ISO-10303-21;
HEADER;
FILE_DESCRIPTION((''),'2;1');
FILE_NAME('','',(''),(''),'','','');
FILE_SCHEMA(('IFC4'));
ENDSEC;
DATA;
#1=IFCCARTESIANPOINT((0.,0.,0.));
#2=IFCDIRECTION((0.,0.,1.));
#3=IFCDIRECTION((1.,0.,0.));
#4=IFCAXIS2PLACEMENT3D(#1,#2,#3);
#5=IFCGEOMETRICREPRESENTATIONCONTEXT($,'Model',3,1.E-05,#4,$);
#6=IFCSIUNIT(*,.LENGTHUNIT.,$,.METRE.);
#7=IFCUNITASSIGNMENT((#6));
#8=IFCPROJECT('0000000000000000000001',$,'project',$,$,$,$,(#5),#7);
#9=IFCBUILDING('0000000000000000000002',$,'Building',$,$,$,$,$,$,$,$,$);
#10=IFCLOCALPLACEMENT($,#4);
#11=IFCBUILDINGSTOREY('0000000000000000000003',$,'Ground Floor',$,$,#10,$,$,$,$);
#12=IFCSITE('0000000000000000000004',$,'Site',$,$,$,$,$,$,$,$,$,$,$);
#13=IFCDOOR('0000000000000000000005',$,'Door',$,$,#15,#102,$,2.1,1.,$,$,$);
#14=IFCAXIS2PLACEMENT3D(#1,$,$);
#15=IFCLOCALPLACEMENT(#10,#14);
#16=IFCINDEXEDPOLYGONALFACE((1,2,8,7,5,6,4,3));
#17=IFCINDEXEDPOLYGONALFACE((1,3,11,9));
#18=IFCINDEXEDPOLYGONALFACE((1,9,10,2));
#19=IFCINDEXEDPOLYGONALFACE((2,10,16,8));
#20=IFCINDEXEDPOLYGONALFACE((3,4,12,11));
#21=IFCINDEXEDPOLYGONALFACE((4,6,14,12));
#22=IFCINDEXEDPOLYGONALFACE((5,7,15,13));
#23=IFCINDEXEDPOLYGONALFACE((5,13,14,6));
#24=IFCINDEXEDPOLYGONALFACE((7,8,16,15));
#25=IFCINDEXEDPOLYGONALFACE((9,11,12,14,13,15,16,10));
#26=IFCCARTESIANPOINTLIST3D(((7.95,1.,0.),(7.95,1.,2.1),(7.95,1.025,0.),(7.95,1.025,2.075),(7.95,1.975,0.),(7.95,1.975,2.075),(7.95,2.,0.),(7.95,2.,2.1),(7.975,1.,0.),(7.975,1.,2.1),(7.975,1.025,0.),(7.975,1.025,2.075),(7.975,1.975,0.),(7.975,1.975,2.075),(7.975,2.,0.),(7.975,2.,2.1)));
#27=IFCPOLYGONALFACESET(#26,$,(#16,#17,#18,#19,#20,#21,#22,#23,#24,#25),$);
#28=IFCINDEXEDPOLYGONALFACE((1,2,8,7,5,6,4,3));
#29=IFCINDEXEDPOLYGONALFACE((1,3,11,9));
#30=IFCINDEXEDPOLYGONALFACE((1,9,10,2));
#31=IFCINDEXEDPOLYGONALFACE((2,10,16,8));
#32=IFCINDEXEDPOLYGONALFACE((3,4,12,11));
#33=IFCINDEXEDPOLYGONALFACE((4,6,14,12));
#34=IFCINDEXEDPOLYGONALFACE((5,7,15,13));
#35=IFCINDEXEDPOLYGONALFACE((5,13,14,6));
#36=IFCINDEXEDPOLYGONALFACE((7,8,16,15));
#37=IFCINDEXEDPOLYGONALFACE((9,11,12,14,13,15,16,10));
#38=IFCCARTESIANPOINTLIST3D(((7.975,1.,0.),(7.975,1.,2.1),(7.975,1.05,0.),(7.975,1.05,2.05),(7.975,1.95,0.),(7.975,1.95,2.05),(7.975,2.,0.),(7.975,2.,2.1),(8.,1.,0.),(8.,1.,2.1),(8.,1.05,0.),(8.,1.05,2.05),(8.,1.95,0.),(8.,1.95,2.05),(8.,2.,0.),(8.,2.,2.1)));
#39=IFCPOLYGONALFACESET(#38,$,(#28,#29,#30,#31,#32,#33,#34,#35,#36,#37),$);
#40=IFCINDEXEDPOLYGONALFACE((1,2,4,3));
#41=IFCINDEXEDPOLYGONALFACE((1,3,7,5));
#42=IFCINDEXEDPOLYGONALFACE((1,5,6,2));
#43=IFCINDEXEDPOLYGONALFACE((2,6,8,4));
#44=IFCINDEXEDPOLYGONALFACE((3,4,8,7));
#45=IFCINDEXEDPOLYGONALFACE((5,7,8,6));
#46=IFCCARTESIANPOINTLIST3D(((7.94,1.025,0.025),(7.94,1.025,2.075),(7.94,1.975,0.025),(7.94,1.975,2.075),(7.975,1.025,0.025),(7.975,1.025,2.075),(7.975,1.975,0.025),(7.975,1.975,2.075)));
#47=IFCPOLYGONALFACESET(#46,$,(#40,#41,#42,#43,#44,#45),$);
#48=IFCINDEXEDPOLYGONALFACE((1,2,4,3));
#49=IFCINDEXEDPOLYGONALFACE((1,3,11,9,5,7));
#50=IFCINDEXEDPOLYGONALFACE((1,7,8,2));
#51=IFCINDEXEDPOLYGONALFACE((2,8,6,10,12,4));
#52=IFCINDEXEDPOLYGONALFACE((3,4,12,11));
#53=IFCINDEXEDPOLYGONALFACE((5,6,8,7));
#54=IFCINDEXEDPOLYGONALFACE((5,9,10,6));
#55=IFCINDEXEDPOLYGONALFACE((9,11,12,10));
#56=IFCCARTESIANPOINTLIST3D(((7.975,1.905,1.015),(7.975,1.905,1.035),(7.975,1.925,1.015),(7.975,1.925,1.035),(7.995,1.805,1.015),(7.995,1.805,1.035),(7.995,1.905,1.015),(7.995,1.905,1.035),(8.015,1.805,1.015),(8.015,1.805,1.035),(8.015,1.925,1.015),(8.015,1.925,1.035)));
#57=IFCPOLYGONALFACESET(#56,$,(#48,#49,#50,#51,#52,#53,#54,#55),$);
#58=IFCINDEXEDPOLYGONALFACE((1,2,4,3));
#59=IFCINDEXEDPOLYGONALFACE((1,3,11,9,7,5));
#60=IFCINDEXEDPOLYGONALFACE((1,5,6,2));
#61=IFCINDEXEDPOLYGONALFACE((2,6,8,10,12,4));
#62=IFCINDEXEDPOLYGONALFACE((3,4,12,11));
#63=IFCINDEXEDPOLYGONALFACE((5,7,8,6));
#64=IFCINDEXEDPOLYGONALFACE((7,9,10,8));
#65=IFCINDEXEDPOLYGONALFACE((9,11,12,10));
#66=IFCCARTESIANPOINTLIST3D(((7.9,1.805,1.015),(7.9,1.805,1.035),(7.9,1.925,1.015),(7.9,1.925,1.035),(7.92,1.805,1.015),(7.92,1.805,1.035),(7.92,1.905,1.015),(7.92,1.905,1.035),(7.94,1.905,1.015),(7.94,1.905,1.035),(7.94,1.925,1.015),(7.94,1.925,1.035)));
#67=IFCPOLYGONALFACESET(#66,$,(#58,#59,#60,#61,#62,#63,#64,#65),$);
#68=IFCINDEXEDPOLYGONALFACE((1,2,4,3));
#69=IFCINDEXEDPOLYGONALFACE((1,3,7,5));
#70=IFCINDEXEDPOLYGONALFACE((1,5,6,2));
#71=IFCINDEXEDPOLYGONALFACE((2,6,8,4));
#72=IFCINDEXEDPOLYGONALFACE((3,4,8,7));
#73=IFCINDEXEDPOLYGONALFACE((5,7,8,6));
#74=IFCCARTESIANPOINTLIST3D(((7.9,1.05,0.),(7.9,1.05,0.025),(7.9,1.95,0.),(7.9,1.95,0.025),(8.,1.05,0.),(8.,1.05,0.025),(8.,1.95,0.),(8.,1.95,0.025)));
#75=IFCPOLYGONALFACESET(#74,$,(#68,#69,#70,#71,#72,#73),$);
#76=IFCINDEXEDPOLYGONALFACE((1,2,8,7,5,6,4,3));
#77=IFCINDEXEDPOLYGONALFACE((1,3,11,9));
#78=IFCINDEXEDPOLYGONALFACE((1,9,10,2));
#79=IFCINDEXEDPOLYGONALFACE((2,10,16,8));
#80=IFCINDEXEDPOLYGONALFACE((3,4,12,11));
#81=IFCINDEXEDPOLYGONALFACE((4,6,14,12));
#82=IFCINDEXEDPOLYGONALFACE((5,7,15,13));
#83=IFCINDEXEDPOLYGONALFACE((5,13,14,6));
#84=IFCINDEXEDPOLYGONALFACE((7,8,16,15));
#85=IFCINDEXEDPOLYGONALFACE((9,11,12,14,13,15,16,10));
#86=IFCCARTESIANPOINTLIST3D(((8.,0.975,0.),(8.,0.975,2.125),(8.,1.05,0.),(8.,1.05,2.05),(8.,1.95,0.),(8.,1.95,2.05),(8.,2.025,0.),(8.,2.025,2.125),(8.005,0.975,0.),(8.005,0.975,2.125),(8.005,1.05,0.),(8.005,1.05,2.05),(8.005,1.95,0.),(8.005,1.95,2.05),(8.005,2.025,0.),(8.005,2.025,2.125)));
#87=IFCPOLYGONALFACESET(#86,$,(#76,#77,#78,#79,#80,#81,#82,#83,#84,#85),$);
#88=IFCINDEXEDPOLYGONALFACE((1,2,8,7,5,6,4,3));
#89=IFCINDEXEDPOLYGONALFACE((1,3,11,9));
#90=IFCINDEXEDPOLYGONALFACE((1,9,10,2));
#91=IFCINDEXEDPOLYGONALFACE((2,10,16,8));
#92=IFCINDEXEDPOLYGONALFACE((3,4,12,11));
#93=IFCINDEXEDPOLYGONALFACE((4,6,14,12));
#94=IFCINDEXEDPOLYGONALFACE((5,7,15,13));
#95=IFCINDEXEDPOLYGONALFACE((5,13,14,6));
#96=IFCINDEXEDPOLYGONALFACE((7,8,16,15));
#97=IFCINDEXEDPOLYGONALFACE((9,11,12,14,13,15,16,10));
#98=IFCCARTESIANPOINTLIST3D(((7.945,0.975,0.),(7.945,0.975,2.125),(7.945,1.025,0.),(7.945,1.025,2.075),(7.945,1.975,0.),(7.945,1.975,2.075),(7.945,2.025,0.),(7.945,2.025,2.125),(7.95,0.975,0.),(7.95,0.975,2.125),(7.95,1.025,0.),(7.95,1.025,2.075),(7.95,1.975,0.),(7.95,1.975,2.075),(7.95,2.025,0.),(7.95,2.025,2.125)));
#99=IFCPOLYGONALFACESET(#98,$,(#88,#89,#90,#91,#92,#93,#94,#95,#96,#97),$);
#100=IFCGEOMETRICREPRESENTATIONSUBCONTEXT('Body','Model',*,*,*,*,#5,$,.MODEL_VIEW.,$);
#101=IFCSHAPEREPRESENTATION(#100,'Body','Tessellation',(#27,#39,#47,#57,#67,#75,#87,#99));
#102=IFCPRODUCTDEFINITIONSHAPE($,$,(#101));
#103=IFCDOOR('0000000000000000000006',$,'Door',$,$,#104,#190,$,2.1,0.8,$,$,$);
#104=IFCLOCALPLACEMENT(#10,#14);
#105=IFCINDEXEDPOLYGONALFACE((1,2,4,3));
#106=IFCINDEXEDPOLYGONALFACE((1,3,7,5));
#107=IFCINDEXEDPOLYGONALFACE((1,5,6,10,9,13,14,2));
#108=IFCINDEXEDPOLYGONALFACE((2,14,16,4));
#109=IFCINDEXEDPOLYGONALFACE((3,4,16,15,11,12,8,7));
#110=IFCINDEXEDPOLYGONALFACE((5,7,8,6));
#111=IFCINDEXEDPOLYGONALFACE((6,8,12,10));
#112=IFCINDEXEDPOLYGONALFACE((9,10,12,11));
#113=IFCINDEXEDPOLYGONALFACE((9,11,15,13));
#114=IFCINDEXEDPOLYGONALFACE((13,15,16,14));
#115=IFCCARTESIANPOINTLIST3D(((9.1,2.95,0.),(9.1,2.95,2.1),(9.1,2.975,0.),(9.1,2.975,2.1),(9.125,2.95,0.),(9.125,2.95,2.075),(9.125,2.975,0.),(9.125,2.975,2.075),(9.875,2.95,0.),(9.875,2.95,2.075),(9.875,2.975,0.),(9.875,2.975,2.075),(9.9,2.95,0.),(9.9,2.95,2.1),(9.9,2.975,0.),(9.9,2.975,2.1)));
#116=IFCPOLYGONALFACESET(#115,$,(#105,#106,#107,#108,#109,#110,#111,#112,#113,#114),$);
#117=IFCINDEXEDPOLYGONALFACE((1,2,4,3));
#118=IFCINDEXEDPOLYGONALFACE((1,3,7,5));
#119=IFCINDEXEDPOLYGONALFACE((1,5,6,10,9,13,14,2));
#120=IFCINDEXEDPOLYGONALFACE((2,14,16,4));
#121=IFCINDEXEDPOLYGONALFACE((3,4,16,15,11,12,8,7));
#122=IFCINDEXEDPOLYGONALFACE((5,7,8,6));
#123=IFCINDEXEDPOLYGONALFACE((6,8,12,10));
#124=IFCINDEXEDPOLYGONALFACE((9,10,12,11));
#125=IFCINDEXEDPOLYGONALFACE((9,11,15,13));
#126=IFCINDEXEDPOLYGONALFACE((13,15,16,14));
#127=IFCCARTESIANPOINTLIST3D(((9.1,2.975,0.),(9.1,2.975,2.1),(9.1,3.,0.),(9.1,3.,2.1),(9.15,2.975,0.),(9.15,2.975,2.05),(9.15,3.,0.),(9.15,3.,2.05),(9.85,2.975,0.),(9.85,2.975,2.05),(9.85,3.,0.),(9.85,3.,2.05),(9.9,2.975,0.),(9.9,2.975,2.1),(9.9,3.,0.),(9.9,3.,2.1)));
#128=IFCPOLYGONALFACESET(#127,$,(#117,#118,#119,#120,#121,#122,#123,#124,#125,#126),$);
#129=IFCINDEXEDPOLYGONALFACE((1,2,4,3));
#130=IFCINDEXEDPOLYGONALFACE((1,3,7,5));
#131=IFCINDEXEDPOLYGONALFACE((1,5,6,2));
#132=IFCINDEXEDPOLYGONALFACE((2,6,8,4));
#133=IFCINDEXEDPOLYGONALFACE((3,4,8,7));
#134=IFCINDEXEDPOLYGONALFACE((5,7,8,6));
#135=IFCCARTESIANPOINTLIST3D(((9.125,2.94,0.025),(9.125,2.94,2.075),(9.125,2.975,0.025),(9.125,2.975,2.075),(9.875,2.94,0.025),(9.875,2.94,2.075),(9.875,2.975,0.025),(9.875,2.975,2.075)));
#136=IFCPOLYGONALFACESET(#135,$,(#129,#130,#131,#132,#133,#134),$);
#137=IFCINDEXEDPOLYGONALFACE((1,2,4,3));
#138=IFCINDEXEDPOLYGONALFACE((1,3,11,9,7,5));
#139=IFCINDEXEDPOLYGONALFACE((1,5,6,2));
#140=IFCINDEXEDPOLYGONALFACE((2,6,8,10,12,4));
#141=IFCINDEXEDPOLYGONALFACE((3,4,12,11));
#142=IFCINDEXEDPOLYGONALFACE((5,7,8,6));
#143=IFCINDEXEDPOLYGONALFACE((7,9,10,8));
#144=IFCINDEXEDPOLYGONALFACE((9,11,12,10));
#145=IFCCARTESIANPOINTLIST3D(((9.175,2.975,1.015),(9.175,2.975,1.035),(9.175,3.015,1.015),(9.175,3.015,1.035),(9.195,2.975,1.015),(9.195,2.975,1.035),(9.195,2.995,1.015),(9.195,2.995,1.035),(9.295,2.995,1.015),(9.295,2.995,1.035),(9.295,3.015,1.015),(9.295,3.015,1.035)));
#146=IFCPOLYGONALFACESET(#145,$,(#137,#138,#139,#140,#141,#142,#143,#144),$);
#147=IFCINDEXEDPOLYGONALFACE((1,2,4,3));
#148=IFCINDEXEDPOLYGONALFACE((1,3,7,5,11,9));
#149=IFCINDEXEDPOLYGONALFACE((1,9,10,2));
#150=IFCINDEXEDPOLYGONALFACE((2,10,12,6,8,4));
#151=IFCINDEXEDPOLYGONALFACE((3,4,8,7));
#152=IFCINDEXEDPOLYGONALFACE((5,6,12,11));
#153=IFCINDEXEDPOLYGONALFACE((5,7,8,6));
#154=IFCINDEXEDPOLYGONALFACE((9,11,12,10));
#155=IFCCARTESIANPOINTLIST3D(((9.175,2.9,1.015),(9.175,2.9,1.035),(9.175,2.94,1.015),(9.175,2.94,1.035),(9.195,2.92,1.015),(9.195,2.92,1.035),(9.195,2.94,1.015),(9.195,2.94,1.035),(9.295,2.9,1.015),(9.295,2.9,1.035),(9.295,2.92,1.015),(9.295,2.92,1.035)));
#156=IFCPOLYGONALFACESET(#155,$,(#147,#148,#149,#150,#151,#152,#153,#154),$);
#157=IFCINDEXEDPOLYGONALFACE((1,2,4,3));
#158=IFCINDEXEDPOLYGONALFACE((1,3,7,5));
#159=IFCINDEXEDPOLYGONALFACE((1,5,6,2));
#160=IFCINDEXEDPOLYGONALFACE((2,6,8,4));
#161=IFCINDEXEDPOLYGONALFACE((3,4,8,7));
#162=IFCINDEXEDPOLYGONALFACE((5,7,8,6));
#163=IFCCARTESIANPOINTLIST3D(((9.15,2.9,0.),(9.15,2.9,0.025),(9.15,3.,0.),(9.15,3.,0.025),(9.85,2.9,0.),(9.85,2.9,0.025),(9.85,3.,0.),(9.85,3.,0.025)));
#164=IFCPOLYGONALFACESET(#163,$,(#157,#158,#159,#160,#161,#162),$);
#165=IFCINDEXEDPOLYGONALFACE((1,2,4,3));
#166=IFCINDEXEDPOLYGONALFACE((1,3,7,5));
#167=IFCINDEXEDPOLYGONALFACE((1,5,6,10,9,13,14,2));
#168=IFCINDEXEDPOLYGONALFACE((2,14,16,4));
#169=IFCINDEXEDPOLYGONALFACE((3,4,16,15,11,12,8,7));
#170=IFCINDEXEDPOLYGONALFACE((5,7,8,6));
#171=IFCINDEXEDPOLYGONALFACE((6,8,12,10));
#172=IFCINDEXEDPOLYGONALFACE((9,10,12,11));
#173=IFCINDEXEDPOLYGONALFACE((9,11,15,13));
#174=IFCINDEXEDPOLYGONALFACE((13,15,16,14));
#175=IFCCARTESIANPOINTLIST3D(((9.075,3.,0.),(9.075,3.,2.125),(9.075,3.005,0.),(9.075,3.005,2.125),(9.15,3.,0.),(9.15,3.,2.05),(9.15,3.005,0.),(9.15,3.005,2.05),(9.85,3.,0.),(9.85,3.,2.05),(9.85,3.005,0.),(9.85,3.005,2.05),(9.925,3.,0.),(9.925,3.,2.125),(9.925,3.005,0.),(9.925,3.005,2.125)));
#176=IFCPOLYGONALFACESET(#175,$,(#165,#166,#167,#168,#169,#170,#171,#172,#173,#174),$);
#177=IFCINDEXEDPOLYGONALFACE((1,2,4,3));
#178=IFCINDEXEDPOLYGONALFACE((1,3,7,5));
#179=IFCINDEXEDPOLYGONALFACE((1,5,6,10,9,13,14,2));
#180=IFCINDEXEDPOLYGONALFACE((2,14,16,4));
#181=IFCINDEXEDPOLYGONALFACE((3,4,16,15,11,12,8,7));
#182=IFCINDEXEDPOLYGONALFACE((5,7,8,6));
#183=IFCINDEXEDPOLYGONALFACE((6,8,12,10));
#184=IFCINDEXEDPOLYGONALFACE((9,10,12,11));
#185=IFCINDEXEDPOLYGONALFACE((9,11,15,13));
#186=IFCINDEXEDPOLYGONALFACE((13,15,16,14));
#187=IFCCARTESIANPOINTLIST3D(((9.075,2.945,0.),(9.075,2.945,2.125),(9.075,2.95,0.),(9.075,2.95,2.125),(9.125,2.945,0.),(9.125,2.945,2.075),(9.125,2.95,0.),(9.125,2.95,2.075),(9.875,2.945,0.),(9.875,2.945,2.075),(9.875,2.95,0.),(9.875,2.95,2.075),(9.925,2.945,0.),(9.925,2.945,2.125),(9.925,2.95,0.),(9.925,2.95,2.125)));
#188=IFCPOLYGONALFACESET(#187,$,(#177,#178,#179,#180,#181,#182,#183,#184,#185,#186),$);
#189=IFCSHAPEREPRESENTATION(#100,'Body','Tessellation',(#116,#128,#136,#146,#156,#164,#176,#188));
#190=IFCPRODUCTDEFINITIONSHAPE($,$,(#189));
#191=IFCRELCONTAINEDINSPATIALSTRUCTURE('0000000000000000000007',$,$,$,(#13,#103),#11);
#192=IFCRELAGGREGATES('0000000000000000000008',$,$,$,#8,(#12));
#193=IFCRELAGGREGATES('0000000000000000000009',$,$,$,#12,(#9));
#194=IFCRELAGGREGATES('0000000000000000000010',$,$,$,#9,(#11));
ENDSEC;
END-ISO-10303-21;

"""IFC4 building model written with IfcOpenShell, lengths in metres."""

from ifc_helpers import new_model, si_unit, frame, origin_with_axes, place, context, subcontext, project, spatial, line, indexed_curve, outline, extrude, element, save


model = new_model("IFC4")

# Units and contexts
model_context = context("Model", 3, precision=1e-05, world=origin_with_axes())
body_context = subcontext(model_context, "Body", "Model", "MODEL_VIEW")
ifc_project = project(units=[si_unit("LENGTHUNIT", "METRE")], contexts=[model_context])

# Site, building, storey
site = spatial("IfcSite", under=ifc_project, Name="Site")
building = spatial("IfcBuilding", under=site, Name="Building")
storey_placement = place(None, origin_with_axes())
storey = spatial("IfcBuildingStorey", under=building, at=storey_placement, Name="Ground Floor")

# Doors
door_1_placement = place(storey_placement, frame((8.0, 1.0, 0.0), z_axis=(0.0, 0.0, 1.0), x_axis=(0.0, 1.0, 0.0)))
element("IfcDoor", 1, at=door_1_placement, inside=storey, Name="Door", OverallHeight=2.1, OverallWidth=1.0, context=body_context, shape_type="SweptSolid", body=[
    extrude(outline(indexed_curve([(0.0, 0.0), (0.0, 2.1), (1.0, 2.1), (1.0, 0.0), (0.975, 0.0), (0.975, 2.075), (0.025, 2.075), (0.025, 0.0)], segments=[line(1, 2, 3, 4, 5, 6, 7, 8, 1)])), frame((0.0, 0.025, 0.0), z_axis=(0.0, -1.0, 0.0), x_axis=(1.0, 0.0, 0.0)), (0.0, 0.0, -1.0), 0.025),
    extrude(outline(indexed_curve([(0.0, 0.0), (0.0, 2.1), (1.0, 2.1), (1.0, 0.0), (0.95, 0.0), (0.95, 2.05), (0.05, 2.05), (0.05, 0.0)], segments=[line(1, 2, 3, 4, 5, 6, 7, 8, 1)])), frame((0.0, 0.0, 0.0), z_axis=(0.0, -1.0, 0.0), x_axis=(1.0, 0.0, 0.0)), (0.0, 0.0, -1.0), 0.025),
    extrude(outline(indexed_curve([(0.0, 0.0), (0.95, 0.0), (0.95, 0.035), (0.0, 0.035)], segments=[line(1, 2, 3, 4, 1)])), frame((0.025, 0.025, 0.025), z_axis=(0.0, 0.0, 1.0), x_axis=(1.0, 0.0, 0.0)), (0.0, 0.0, 1.0), 2.05),
    extrude(outline(indexed_curve([(0.0, 0.0), (0.0, -0.04), (-0.12, -0.04), (-0.12, -0.02), (-0.02, -0.02), (-0.02, 0.0)], segments=[line(1, 2, 3, 4, 5, 6, 1)])), frame((0.925, 0.025, 1.015), z_axis=(0.0, 0.0, 1.0), x_axis=(1.0, 0.0, 0.0)), (0.0, 0.0, 1.0), 0.02),
    extrude(outline(indexed_curve([(0.0, 0.0), (0.0, 0.04), (-0.12, 0.04), (-0.12, 0.02), (-0.02, 0.02), (-0.02, 0.0)], segments=[line(1, 2, 3, 4, 5, 6, 1)])), frame((0.925, 0.06, 1.015), z_axis=(0.0, 0.0, 1.0), x_axis=(1.0, 0.0, 0.0)), (0.0, 0.0, 1.0), 0.02),
    extrude(outline(indexed_curve([(0.0, 0.0), (0.9, 0.0), (0.9, 0.1), (0.0, 0.1)], segments=[line(1, 2, 3, 4, 1)])), frame((0.05, 0.0, 0.0), z_axis=(0.0, 0.0, 1.0), x_axis=(1.0, 0.0, 0.0)), (0.0, 0.0, 1.0), 0.025),
    extrude(outline(indexed_curve([(0.0, 0.0), (0.0, 2.125), (1.05, 2.125), (1.05, 0.0), (0.975, 0.0), (0.975, 2.05), (0.075, 2.05), (0.075, 0.0)], segments=[line(1, 2, 3, 4, 5, 6, 7, 8, 1)])), frame((-0.025, -0.005, 0.0), z_axis=(0.0, -1.0, 0.0), x_axis=(1.0, 0.0, 0.0)), (0.0, 0.0, -1.0), 0.005),
    extrude(outline(indexed_curve([(0.0, 0.0), (0.0, 2.125), (1.05, 2.125), (1.05, 0.0), (1.0, 0.0), (1.0, 2.075), (0.05, 2.075), (0.05, 0.0)], segments=[line(1, 2, 3, 4, 5, 6, 7, 8, 1)])), frame((-0.025, 0.05, 0.0), z_axis=(0.0, -1.0, 0.0), x_axis=(1.0, 0.0, 0.0)), (0.0, 0.0, -1.0), 0.005),
])
door_2_placement = place(storey_placement, frame((9.9, 3.0, 0.0), z_axis=(0.0, 0.0, 1.0), x_axis=(-1.0, 0.0, 0.0)))
element("IfcDoor", 2, at=door_2_placement, inside=storey, Name="Door", OverallHeight=2.1, OverallWidth=0.8, context=body_context, shape_type="SweptSolid", body=[
    extrude(outline(indexed_curve([(0.0, 0.0), (0.0, 2.1), (0.8, 2.1), (0.8, 0.0), (0.775, 0.0), (0.775, 2.075), (0.025, 2.075), (0.025, 0.0)], segments=[line(1, 2, 3, 4, 5, 6, 7, 8, 1)])), frame((0.0, 0.025, 0.0), z_axis=(0.0, -1.0, 0.0), x_axis=(1.0, 0.0, 0.0)), (0.0, 0.0, -1.0), 0.025),
    extrude(outline(indexed_curve([(0.0, 0.0), (0.0, 2.1), (0.8, 2.1), (0.8, 0.0), (0.75, 0.0), (0.75, 2.05), (0.05, 2.05), (0.05, 0.0)], segments=[line(1, 2, 3, 4, 5, 6, 7, 8, 1)])), frame((0.0, 0.0, 0.0), z_axis=(0.0, -1.0, 0.0), x_axis=(1.0, 0.0, 0.0)), (0.0, 0.0, -1.0), 0.025),
    extrude(outline(indexed_curve([(0.0, 0.0), (0.75, 0.0), (0.75, 0.035), (0.0, 0.035)], segments=[line(1, 2, 3, 4, 1)])), frame((0.025, 0.025, 0.025), z_axis=(0.0, 0.0, 1.0), x_axis=(1.0, 0.0, 0.0)), (0.0, 0.0, 1.0), 2.05),
    extrude(outline(indexed_curve([(0.0, 0.0), (0.0, -0.04), (-0.12, -0.04), (-0.12, -0.02), (-0.02, -0.02), (-0.02, 0.0)], segments=[line(1, 2, 3, 4, 5, 6, 1)])), frame((0.725, 0.025, 1.015), z_axis=(0.0, 0.0, 1.0), x_axis=(1.0, 0.0, 0.0)), (0.0, 0.0, 1.0), 0.02),
    extrude(outline(indexed_curve([(0.0, 0.0), (0.0, 0.04), (-0.12, 0.04), (-0.12, 0.02), (-0.02, 0.02), (-0.02, 0.0)], segments=[line(1, 2, 3, 4, 5, 6, 1)])), frame((0.725, 0.06, 1.015), z_axis=(0.0, 0.0, 1.0), x_axis=(1.0, 0.0, 0.0)), (0.0, 0.0, 1.0), 0.02),
    extrude(outline(indexed_curve([(0.0, 0.0), (0.7, 0.0), (0.7, 0.1), (0.0, 0.1)], segments=[line(1, 2, 3, 4, 1)])), frame((0.05, 0.0, 0.0), z_axis=(0.0, 0.0, 1.0), x_axis=(1.0, 0.0, 0.0)), (0.0, 0.0, 1.0), 0.025),
    extrude(outline(indexed_curve([(0.0, 0.0), (0.0, 2.125), (0.85, 2.125), (0.85, 0.0), (0.775, 0.0), (0.775, 2.05), (0.075, 2.05), (0.075, 0.0)], segments=[line(1, 2, 3, 4, 5, 6, 7, 8, 1)])), frame((-0.025, -0.005, 0.0), z_axis=(0.0, -1.0, 0.0), x_axis=(1.0, 0.0, 0.0)), (0.0, 0.0, -1.0), 0.005),
    extrude(outline(indexed_curve([(0.0, 0.0), (0.0, 2.125), (0.85, 2.125), (0.85, 0.0), (0.8, 0.0), (0.8, 2.075), (0.05, 2.075), (0.05, 0.0)], segments=[line(1, 2, 3, 4, 5, 6, 7, 8, 1)])), frame((-0.025, 0.05, 0.0), z_axis=(0.0, -1.0, 0.0), x_axis=(1.0, 0.0, 0.0)), (0.0, 0.0, -1.0), 0.005),
])

save(model, "model.ifc")
